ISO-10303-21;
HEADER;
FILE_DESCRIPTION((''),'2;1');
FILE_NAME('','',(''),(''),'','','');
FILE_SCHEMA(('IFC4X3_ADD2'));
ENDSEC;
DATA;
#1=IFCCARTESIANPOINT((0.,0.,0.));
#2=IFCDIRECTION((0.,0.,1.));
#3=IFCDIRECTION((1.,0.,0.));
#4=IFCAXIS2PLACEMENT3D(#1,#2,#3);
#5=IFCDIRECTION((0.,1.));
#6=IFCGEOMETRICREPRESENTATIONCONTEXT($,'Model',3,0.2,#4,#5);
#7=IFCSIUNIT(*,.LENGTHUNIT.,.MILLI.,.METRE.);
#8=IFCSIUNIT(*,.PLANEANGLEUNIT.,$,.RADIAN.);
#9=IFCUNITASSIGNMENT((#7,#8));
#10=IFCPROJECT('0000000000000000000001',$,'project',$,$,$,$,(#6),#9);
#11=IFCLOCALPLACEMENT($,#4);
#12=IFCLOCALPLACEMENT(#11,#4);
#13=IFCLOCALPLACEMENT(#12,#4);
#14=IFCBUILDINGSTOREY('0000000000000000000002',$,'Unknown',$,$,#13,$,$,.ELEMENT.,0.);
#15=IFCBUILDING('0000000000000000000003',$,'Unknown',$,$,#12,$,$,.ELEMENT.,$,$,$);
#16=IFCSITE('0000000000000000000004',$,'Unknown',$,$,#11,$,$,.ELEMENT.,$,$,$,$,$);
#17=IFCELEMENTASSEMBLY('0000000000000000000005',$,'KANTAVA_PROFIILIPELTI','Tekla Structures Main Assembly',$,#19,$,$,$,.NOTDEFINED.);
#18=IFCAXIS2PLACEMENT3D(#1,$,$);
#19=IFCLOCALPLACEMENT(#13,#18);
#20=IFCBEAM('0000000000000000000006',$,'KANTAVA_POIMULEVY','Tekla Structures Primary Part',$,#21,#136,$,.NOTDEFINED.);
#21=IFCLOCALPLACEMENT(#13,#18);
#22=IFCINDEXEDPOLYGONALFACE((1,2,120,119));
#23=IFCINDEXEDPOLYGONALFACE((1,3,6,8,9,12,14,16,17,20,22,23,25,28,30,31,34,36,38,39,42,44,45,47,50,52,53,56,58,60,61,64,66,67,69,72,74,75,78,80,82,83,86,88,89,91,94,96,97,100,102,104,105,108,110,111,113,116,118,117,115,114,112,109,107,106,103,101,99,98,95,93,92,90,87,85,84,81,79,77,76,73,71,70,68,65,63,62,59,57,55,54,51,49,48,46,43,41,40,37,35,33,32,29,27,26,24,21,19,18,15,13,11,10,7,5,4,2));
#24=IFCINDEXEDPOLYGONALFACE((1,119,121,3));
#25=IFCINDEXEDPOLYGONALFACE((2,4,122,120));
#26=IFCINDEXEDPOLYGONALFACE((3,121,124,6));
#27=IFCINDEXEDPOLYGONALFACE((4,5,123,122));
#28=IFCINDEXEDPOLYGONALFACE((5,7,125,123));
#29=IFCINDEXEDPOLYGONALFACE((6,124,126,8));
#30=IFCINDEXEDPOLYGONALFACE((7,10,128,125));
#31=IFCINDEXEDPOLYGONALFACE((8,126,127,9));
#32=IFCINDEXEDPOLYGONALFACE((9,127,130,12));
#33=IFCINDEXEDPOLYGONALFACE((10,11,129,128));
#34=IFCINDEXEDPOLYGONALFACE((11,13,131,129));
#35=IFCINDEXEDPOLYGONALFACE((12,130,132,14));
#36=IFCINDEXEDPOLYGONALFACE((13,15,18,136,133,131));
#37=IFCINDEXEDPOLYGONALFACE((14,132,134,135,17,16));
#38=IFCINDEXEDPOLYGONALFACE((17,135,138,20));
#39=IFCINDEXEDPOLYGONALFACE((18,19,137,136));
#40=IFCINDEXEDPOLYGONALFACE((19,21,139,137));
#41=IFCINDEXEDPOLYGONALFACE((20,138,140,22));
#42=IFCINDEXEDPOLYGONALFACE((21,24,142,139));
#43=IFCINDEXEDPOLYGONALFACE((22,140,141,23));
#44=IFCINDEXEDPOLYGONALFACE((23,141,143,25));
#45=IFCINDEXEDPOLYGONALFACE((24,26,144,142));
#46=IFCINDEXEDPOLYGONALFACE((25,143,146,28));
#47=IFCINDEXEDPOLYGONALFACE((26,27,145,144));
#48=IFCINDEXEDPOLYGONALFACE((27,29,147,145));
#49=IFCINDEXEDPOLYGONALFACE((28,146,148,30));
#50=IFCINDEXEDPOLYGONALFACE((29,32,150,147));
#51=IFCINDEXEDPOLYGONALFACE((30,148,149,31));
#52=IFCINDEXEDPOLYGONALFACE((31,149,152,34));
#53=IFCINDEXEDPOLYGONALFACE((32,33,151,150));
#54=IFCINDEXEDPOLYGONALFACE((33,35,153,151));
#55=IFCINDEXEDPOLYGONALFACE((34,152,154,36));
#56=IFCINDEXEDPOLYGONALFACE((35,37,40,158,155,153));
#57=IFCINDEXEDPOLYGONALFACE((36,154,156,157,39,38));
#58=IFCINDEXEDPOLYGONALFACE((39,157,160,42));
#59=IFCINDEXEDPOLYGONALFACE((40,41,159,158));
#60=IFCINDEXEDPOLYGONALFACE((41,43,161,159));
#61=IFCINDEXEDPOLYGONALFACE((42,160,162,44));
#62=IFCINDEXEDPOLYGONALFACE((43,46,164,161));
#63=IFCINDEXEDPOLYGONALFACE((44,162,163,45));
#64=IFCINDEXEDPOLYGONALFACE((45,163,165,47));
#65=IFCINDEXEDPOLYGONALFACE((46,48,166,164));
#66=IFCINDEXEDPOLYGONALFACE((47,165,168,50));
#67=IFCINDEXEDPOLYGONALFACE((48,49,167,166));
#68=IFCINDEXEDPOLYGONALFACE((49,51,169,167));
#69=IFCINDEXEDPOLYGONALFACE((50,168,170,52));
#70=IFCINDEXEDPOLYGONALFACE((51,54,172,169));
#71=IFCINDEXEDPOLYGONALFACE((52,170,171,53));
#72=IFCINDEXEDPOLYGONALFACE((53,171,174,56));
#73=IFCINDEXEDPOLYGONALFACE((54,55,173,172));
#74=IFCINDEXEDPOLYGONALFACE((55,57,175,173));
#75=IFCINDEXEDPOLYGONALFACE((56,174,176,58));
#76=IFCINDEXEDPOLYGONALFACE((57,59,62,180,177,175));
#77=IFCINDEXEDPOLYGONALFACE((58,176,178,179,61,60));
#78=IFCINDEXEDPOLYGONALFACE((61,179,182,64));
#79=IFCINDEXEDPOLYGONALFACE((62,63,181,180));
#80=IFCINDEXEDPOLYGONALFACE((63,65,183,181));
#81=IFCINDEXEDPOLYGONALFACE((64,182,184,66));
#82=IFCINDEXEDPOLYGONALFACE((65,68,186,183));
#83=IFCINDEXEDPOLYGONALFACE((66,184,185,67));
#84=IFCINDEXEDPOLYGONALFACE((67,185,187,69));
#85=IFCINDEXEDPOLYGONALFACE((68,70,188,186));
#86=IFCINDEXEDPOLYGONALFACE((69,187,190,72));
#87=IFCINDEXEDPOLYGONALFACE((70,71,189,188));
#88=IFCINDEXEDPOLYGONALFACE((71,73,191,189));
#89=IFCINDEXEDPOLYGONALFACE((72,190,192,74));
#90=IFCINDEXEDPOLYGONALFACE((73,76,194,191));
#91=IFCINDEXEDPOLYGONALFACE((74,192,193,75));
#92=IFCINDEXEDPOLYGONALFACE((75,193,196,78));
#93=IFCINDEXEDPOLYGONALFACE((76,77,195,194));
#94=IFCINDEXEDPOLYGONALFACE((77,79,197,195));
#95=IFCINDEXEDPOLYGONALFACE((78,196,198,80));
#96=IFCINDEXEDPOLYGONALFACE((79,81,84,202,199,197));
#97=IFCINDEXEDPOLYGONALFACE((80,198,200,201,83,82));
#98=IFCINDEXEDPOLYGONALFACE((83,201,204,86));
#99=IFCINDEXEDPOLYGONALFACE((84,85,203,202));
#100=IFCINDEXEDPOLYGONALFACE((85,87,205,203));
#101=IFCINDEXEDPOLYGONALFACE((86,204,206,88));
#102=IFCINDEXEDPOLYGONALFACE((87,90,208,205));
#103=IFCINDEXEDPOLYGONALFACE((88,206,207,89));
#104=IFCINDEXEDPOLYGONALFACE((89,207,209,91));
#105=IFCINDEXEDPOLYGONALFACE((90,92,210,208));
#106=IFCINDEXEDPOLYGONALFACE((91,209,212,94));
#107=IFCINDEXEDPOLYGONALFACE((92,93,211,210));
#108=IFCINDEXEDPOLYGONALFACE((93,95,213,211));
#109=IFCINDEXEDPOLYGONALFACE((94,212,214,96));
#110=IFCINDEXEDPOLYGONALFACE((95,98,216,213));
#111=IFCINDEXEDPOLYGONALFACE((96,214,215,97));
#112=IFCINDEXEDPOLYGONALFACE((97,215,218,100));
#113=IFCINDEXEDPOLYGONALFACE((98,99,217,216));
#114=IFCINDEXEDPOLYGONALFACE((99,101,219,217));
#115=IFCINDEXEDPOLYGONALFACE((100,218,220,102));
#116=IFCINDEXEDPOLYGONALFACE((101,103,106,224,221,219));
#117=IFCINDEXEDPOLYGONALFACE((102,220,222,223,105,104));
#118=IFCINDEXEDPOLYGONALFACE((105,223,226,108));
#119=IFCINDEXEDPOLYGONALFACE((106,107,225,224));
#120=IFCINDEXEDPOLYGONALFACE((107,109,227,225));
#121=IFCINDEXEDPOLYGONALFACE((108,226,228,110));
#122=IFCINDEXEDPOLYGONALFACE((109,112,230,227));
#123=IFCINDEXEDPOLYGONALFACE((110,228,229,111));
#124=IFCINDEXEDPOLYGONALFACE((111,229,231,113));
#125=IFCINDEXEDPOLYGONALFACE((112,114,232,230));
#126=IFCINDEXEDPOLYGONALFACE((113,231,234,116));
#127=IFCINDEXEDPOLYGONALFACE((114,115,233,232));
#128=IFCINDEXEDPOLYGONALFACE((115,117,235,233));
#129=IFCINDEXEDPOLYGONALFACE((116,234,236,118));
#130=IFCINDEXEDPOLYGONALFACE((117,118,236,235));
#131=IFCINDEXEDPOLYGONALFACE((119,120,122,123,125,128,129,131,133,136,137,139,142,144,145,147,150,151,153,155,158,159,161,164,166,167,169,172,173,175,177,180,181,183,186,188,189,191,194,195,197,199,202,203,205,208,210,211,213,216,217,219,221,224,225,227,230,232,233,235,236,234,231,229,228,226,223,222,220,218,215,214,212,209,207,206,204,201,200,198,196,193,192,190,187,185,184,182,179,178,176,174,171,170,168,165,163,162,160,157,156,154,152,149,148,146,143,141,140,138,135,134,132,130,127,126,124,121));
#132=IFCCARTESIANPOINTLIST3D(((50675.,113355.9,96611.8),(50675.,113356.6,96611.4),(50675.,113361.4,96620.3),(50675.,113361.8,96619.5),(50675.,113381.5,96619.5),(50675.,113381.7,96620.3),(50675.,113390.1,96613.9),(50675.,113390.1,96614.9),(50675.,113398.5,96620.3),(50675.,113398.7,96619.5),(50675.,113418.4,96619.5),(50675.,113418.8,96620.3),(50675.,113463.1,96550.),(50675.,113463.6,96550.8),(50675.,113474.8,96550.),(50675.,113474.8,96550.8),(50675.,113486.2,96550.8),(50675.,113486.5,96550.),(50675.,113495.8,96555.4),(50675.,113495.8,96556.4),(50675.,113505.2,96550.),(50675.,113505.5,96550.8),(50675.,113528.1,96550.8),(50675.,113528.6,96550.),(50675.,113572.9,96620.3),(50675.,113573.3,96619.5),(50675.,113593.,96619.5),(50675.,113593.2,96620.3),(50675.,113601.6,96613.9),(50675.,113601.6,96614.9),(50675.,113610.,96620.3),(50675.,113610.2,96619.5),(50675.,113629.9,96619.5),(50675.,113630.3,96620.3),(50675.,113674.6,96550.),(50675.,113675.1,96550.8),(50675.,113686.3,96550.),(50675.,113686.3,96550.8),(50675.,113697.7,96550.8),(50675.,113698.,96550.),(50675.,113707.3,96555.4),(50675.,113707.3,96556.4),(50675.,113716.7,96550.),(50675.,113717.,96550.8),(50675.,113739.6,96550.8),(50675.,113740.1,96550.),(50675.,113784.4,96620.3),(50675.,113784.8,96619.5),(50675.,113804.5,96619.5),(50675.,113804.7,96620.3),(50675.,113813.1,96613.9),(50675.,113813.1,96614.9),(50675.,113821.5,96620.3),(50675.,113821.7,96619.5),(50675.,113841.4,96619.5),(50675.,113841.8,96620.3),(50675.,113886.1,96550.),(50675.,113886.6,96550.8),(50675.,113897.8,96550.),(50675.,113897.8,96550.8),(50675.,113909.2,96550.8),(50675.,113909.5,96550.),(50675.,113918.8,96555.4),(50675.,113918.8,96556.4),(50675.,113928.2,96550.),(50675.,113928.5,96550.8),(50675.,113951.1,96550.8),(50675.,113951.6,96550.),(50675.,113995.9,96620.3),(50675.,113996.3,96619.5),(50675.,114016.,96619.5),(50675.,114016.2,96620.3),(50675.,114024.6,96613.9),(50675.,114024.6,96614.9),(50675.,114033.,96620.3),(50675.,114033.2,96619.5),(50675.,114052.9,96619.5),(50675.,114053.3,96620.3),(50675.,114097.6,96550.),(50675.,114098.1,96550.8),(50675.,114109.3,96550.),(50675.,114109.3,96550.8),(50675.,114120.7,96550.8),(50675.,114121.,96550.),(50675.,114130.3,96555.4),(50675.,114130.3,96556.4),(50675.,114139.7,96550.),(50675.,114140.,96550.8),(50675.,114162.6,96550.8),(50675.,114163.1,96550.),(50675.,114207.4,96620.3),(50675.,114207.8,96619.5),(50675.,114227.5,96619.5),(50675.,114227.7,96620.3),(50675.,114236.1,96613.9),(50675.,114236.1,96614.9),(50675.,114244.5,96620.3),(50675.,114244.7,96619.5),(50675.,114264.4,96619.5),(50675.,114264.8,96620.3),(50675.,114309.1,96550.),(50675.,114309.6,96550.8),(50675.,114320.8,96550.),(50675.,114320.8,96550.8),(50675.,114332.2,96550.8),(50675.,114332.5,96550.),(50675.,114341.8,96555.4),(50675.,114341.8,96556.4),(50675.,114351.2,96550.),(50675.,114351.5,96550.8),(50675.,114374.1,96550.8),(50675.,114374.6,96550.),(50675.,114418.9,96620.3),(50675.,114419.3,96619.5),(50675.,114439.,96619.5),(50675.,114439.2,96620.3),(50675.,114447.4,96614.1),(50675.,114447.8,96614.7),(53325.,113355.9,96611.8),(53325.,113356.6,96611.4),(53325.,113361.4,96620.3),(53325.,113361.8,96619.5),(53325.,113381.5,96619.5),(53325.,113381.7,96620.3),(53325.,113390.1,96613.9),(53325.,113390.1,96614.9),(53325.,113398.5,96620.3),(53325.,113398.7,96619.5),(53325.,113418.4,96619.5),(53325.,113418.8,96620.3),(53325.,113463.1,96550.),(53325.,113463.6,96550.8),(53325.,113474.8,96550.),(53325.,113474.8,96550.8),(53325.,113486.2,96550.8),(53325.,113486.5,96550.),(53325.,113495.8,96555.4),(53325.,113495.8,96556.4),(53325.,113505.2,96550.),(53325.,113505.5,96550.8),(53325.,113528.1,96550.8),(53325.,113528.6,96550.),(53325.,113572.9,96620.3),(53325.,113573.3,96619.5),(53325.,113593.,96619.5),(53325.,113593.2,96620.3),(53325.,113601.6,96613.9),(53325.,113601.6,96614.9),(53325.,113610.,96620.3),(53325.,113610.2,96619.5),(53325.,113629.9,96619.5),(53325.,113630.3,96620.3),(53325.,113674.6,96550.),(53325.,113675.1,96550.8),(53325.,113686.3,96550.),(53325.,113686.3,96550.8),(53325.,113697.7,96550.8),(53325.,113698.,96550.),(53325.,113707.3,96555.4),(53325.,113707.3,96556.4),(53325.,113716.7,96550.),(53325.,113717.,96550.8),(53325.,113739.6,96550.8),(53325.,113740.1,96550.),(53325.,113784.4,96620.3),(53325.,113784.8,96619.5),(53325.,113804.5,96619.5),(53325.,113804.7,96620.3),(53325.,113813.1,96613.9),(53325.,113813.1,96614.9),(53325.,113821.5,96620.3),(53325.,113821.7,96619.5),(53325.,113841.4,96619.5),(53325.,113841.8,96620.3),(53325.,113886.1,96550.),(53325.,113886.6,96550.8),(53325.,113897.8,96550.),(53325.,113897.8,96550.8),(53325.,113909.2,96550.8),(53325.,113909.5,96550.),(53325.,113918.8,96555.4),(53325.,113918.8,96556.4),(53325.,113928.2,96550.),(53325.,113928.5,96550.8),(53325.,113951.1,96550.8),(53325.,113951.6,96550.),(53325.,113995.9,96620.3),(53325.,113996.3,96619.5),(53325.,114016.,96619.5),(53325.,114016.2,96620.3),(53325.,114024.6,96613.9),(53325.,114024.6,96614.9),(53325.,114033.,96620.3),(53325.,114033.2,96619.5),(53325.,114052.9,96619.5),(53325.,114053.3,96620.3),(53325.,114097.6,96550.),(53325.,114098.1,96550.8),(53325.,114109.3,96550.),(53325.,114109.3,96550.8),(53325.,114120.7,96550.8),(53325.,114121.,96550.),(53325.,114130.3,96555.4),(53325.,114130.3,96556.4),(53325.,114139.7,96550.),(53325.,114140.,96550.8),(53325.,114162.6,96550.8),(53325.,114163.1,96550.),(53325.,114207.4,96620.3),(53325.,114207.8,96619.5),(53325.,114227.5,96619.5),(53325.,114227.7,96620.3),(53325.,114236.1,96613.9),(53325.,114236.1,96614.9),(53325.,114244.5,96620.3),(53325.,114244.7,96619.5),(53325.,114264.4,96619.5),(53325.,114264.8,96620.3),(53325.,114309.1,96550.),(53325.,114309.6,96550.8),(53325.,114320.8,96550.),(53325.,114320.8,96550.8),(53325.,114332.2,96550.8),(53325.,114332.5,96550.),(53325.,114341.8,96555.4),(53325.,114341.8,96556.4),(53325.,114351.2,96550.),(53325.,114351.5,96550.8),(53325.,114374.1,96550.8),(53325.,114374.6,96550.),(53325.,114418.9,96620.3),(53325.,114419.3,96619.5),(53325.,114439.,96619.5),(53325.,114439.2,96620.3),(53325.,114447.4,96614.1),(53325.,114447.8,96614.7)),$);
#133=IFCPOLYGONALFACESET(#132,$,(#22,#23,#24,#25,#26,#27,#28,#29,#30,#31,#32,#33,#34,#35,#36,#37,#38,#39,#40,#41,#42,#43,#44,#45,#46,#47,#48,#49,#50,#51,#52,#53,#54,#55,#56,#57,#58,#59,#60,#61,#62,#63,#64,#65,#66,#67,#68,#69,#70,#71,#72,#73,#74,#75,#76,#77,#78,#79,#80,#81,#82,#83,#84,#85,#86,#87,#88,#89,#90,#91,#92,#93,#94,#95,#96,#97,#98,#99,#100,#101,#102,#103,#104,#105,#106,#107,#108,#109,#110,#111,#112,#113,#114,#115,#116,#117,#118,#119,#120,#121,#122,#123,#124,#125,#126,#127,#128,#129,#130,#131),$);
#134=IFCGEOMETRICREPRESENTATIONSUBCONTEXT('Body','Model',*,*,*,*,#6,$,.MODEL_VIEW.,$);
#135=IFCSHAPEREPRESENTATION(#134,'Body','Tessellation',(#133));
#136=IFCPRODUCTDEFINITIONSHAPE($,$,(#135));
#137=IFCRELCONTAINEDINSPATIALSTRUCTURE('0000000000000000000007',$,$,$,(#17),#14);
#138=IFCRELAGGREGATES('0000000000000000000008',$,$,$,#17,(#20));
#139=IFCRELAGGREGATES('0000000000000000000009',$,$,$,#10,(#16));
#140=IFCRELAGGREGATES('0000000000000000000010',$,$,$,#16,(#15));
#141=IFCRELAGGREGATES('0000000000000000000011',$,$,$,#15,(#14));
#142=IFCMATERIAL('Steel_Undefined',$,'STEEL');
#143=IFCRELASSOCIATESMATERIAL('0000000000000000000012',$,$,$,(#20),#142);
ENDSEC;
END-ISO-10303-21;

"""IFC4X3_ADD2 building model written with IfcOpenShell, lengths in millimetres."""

from ifc_helpers import new_model, si_unit, direction, frame, origin_with_axes, place, context, subcontext, project, spatial, line, indexed_curve, outline, extrude, material, element, aggregate, save


model = new_model("IFC4X3_ADD2")

# Units and contexts
model_context = context("Model", 3, precision=0.2, world=origin_with_axes(), true_north=direction((0.0, 1.0)))
body_context = subcontext(model_context, "Body", "Model", "MODEL_VIEW")
ifc_project = project(units=[si_unit("LENGTHUNIT", "METRE", prefix="MILLI"), si_unit("PLANEANGLEUNIT", "RADIAN")], contexts=[model_context])

# Site, building, storey
site_placement = place(None, origin_with_axes())
site = spatial("IfcSite", under=ifc_project, at=site_placement, Name="Unknown", CompositionType="ELEMENT")
building_placement = place(site_placement, origin_with_axes())
building = spatial("IfcBuilding", under=site, at=building_placement, Name="Unknown", CompositionType="ELEMENT")
storey_placement = place(building_placement, origin_with_axes())
storey = spatial("IfcBuildingStorey", under=building, at=storey_placement, Name="Unknown", CompositionType="ELEMENT", Elevation=0.0)

# Element assembly, beam
ifc_material_1 = material(Name="Steel_Undefined", Category="STEEL")
assembly_1_placement = place(storey_placement, frame((53325.0, 113918.8, 96585.2), z_axis=(0.0, 1.0, 0.0), x_axis=(-1.0, 0.0, 0.0)))
assembly_1 = element("IfcElementAssembly", 1, at=assembly_1_placement, inside=storey, Name="KANTAVA_PROFIILIPELTI", Description="Tekla Structures Main Assembly", PredefinedType="NOTDEFINED")
beam_1_placement = place(assembly_1_placement, origin_with_axes())
beam_1 = element("IfcBeam", 2, at=beam_1_placement, material=ifc_material_1, Name="KANTAVA_POIMULEVY", Description="Tekla Structures Primary Part", PredefinedType="NOTDEFINED", context=body_context, shape_type="SolidModel", body=[
    extrude(outline(indexed_curve([(529.0, 29.6), (520.4, 35.1), (500.0, 35.1), (455.3, -34.4), (432.6, -34.4), (423.0, -28.8), (413.4, -34.4), (402.0, -34.4), (390.7, -34.4), (346.0, 35.1), (325.6, 35.1), (317.2, 29.7), (308.9, 35.1), (288.5, 35.1), (243.8, -34.4), (221.1, -34.4), (211.5, -28.8), (201.9, -34.4), (190.5, -34.4), (179.2, -34.4), (134.5, 35.1), (114.1, 35.1), (105.8, 29.7), (97.4, 35.1), (77.0, 35.1), (32.3, -34.4), (9.6, -34.4), (0.0, -28.8), (-9.6, -34.4), (-21.0, -34.4), (-32.3, -34.4), (-77.0, 35.1), (-97.4, 35.1), (-105.8, 29.7), (-114.1, 35.1), (-134.5, 35.1), (-179.2, -34.4), (-201.9, -34.4), (-211.5, -28.8), (-221.1, -34.4), (-232.5, -34.4), (-243.8, -34.4), (-288.5, 35.1), (-308.9, 35.1), (-317.2, 29.7), (-325.6, 35.1), (-346.0, 35.1), (-390.7, -34.4), (-413.4, -34.4), (-423.0, -28.8), (-432.6, -34.4), (-444.0, -34.4), (-455.3, -34.4), (-500.0, 35.1), (-520.4, 35.1), (-528.8, 29.7), (-537.1, 35.1), (-557.5, 35.1), (-562.9, 26.7), (-562.2, 26.2), (-557.0, 34.4), (-537.4, 34.4), (-528.8, 28.8), (-520.1, 34.4), (-500.5, 34.4), (-455.7, -35.1), (-444.0, -35.1), (-432.4, -35.1), (-423.0, -29.7), (-413.6, -35.1), (-390.3, -35.1), (-345.5, 34.4), (-325.9, 34.4), (-317.2, 28.8), (-308.6, 34.4), (-289.0, 34.4), (-244.2, -35.1), (-232.5, -35.1), (-220.9, -35.1), (-211.5, -29.7), (-202.1, -35.1), (-178.8, -35.1), (-134.0, 34.4), (-114.4, 34.4), (-105.8, 28.8), (-97.1, 34.4), (-77.5, 34.4), (-32.7, -35.1), (-21.0, -35.1), (-9.4, -35.1), (0.0, -29.7), (9.4, -35.1), (32.7, -35.1), (77.5, 34.4), (97.1, 34.4), (105.8, 28.8), (114.4, 34.4), (134.0, 34.4), (178.8, -35.1), (190.5, -35.1), (202.1, -35.1), (211.5, -29.7), (220.9, -35.1), (244.2, -35.1), (289.0, 34.4), (308.6, 34.4), (317.2, 28.8), (325.9, 34.4), (345.5, 34.4), (390.3, -35.1), (402.0, -35.1), (413.6, -35.1), (423.0, -29.7), (432.4, -35.1), (455.7, -35.1), (500.5, 34.4), (520.1, 34.4), (528.5, 28.9)], segments=[line(1, 2, 3, 4, 5, 6, 7, 8, 9, 10, 11, 12, 13, 14, 15, 16, 17, 18, 19, 20, 21, 22, 23, 24, 25, 26, 27, 28, 29, 30, 31, 32, 33, 34, 35, 36, 37, 38, 39, 40, 41, 42, 43, 44, 45, 46, 47, 48, 49, 50, 51, 52, 53, 54, 55, 56, 57, 58, 59, 60, 61, 62, 63, 64, 65, 66, 67, 68, 69, 70, 71, 72, 73, 74, 75, 76, 77, 78, 79, 80, 81, 82, 83, 84, 85, 86, 87, 88, 89, 90, 91, 92, 93, 94, 95, 96, 97, 98, 99, 100, 101, 102, 103, 104, 105, 106, 107, 108, 109, 110, 111, 112, 113, 114, 115, 116, 117, 118, 1)])), frame((0.0, 0.0, 0.0), z_axis=(-1.0, 0.0, 0.0), x_axis=(0.0, 0.0, 1.0)), (0.0, 0.0, -1.0), 2650.0),
])
aggregate(assembly_1, [beam_1])

save(model, "model.ifc")
